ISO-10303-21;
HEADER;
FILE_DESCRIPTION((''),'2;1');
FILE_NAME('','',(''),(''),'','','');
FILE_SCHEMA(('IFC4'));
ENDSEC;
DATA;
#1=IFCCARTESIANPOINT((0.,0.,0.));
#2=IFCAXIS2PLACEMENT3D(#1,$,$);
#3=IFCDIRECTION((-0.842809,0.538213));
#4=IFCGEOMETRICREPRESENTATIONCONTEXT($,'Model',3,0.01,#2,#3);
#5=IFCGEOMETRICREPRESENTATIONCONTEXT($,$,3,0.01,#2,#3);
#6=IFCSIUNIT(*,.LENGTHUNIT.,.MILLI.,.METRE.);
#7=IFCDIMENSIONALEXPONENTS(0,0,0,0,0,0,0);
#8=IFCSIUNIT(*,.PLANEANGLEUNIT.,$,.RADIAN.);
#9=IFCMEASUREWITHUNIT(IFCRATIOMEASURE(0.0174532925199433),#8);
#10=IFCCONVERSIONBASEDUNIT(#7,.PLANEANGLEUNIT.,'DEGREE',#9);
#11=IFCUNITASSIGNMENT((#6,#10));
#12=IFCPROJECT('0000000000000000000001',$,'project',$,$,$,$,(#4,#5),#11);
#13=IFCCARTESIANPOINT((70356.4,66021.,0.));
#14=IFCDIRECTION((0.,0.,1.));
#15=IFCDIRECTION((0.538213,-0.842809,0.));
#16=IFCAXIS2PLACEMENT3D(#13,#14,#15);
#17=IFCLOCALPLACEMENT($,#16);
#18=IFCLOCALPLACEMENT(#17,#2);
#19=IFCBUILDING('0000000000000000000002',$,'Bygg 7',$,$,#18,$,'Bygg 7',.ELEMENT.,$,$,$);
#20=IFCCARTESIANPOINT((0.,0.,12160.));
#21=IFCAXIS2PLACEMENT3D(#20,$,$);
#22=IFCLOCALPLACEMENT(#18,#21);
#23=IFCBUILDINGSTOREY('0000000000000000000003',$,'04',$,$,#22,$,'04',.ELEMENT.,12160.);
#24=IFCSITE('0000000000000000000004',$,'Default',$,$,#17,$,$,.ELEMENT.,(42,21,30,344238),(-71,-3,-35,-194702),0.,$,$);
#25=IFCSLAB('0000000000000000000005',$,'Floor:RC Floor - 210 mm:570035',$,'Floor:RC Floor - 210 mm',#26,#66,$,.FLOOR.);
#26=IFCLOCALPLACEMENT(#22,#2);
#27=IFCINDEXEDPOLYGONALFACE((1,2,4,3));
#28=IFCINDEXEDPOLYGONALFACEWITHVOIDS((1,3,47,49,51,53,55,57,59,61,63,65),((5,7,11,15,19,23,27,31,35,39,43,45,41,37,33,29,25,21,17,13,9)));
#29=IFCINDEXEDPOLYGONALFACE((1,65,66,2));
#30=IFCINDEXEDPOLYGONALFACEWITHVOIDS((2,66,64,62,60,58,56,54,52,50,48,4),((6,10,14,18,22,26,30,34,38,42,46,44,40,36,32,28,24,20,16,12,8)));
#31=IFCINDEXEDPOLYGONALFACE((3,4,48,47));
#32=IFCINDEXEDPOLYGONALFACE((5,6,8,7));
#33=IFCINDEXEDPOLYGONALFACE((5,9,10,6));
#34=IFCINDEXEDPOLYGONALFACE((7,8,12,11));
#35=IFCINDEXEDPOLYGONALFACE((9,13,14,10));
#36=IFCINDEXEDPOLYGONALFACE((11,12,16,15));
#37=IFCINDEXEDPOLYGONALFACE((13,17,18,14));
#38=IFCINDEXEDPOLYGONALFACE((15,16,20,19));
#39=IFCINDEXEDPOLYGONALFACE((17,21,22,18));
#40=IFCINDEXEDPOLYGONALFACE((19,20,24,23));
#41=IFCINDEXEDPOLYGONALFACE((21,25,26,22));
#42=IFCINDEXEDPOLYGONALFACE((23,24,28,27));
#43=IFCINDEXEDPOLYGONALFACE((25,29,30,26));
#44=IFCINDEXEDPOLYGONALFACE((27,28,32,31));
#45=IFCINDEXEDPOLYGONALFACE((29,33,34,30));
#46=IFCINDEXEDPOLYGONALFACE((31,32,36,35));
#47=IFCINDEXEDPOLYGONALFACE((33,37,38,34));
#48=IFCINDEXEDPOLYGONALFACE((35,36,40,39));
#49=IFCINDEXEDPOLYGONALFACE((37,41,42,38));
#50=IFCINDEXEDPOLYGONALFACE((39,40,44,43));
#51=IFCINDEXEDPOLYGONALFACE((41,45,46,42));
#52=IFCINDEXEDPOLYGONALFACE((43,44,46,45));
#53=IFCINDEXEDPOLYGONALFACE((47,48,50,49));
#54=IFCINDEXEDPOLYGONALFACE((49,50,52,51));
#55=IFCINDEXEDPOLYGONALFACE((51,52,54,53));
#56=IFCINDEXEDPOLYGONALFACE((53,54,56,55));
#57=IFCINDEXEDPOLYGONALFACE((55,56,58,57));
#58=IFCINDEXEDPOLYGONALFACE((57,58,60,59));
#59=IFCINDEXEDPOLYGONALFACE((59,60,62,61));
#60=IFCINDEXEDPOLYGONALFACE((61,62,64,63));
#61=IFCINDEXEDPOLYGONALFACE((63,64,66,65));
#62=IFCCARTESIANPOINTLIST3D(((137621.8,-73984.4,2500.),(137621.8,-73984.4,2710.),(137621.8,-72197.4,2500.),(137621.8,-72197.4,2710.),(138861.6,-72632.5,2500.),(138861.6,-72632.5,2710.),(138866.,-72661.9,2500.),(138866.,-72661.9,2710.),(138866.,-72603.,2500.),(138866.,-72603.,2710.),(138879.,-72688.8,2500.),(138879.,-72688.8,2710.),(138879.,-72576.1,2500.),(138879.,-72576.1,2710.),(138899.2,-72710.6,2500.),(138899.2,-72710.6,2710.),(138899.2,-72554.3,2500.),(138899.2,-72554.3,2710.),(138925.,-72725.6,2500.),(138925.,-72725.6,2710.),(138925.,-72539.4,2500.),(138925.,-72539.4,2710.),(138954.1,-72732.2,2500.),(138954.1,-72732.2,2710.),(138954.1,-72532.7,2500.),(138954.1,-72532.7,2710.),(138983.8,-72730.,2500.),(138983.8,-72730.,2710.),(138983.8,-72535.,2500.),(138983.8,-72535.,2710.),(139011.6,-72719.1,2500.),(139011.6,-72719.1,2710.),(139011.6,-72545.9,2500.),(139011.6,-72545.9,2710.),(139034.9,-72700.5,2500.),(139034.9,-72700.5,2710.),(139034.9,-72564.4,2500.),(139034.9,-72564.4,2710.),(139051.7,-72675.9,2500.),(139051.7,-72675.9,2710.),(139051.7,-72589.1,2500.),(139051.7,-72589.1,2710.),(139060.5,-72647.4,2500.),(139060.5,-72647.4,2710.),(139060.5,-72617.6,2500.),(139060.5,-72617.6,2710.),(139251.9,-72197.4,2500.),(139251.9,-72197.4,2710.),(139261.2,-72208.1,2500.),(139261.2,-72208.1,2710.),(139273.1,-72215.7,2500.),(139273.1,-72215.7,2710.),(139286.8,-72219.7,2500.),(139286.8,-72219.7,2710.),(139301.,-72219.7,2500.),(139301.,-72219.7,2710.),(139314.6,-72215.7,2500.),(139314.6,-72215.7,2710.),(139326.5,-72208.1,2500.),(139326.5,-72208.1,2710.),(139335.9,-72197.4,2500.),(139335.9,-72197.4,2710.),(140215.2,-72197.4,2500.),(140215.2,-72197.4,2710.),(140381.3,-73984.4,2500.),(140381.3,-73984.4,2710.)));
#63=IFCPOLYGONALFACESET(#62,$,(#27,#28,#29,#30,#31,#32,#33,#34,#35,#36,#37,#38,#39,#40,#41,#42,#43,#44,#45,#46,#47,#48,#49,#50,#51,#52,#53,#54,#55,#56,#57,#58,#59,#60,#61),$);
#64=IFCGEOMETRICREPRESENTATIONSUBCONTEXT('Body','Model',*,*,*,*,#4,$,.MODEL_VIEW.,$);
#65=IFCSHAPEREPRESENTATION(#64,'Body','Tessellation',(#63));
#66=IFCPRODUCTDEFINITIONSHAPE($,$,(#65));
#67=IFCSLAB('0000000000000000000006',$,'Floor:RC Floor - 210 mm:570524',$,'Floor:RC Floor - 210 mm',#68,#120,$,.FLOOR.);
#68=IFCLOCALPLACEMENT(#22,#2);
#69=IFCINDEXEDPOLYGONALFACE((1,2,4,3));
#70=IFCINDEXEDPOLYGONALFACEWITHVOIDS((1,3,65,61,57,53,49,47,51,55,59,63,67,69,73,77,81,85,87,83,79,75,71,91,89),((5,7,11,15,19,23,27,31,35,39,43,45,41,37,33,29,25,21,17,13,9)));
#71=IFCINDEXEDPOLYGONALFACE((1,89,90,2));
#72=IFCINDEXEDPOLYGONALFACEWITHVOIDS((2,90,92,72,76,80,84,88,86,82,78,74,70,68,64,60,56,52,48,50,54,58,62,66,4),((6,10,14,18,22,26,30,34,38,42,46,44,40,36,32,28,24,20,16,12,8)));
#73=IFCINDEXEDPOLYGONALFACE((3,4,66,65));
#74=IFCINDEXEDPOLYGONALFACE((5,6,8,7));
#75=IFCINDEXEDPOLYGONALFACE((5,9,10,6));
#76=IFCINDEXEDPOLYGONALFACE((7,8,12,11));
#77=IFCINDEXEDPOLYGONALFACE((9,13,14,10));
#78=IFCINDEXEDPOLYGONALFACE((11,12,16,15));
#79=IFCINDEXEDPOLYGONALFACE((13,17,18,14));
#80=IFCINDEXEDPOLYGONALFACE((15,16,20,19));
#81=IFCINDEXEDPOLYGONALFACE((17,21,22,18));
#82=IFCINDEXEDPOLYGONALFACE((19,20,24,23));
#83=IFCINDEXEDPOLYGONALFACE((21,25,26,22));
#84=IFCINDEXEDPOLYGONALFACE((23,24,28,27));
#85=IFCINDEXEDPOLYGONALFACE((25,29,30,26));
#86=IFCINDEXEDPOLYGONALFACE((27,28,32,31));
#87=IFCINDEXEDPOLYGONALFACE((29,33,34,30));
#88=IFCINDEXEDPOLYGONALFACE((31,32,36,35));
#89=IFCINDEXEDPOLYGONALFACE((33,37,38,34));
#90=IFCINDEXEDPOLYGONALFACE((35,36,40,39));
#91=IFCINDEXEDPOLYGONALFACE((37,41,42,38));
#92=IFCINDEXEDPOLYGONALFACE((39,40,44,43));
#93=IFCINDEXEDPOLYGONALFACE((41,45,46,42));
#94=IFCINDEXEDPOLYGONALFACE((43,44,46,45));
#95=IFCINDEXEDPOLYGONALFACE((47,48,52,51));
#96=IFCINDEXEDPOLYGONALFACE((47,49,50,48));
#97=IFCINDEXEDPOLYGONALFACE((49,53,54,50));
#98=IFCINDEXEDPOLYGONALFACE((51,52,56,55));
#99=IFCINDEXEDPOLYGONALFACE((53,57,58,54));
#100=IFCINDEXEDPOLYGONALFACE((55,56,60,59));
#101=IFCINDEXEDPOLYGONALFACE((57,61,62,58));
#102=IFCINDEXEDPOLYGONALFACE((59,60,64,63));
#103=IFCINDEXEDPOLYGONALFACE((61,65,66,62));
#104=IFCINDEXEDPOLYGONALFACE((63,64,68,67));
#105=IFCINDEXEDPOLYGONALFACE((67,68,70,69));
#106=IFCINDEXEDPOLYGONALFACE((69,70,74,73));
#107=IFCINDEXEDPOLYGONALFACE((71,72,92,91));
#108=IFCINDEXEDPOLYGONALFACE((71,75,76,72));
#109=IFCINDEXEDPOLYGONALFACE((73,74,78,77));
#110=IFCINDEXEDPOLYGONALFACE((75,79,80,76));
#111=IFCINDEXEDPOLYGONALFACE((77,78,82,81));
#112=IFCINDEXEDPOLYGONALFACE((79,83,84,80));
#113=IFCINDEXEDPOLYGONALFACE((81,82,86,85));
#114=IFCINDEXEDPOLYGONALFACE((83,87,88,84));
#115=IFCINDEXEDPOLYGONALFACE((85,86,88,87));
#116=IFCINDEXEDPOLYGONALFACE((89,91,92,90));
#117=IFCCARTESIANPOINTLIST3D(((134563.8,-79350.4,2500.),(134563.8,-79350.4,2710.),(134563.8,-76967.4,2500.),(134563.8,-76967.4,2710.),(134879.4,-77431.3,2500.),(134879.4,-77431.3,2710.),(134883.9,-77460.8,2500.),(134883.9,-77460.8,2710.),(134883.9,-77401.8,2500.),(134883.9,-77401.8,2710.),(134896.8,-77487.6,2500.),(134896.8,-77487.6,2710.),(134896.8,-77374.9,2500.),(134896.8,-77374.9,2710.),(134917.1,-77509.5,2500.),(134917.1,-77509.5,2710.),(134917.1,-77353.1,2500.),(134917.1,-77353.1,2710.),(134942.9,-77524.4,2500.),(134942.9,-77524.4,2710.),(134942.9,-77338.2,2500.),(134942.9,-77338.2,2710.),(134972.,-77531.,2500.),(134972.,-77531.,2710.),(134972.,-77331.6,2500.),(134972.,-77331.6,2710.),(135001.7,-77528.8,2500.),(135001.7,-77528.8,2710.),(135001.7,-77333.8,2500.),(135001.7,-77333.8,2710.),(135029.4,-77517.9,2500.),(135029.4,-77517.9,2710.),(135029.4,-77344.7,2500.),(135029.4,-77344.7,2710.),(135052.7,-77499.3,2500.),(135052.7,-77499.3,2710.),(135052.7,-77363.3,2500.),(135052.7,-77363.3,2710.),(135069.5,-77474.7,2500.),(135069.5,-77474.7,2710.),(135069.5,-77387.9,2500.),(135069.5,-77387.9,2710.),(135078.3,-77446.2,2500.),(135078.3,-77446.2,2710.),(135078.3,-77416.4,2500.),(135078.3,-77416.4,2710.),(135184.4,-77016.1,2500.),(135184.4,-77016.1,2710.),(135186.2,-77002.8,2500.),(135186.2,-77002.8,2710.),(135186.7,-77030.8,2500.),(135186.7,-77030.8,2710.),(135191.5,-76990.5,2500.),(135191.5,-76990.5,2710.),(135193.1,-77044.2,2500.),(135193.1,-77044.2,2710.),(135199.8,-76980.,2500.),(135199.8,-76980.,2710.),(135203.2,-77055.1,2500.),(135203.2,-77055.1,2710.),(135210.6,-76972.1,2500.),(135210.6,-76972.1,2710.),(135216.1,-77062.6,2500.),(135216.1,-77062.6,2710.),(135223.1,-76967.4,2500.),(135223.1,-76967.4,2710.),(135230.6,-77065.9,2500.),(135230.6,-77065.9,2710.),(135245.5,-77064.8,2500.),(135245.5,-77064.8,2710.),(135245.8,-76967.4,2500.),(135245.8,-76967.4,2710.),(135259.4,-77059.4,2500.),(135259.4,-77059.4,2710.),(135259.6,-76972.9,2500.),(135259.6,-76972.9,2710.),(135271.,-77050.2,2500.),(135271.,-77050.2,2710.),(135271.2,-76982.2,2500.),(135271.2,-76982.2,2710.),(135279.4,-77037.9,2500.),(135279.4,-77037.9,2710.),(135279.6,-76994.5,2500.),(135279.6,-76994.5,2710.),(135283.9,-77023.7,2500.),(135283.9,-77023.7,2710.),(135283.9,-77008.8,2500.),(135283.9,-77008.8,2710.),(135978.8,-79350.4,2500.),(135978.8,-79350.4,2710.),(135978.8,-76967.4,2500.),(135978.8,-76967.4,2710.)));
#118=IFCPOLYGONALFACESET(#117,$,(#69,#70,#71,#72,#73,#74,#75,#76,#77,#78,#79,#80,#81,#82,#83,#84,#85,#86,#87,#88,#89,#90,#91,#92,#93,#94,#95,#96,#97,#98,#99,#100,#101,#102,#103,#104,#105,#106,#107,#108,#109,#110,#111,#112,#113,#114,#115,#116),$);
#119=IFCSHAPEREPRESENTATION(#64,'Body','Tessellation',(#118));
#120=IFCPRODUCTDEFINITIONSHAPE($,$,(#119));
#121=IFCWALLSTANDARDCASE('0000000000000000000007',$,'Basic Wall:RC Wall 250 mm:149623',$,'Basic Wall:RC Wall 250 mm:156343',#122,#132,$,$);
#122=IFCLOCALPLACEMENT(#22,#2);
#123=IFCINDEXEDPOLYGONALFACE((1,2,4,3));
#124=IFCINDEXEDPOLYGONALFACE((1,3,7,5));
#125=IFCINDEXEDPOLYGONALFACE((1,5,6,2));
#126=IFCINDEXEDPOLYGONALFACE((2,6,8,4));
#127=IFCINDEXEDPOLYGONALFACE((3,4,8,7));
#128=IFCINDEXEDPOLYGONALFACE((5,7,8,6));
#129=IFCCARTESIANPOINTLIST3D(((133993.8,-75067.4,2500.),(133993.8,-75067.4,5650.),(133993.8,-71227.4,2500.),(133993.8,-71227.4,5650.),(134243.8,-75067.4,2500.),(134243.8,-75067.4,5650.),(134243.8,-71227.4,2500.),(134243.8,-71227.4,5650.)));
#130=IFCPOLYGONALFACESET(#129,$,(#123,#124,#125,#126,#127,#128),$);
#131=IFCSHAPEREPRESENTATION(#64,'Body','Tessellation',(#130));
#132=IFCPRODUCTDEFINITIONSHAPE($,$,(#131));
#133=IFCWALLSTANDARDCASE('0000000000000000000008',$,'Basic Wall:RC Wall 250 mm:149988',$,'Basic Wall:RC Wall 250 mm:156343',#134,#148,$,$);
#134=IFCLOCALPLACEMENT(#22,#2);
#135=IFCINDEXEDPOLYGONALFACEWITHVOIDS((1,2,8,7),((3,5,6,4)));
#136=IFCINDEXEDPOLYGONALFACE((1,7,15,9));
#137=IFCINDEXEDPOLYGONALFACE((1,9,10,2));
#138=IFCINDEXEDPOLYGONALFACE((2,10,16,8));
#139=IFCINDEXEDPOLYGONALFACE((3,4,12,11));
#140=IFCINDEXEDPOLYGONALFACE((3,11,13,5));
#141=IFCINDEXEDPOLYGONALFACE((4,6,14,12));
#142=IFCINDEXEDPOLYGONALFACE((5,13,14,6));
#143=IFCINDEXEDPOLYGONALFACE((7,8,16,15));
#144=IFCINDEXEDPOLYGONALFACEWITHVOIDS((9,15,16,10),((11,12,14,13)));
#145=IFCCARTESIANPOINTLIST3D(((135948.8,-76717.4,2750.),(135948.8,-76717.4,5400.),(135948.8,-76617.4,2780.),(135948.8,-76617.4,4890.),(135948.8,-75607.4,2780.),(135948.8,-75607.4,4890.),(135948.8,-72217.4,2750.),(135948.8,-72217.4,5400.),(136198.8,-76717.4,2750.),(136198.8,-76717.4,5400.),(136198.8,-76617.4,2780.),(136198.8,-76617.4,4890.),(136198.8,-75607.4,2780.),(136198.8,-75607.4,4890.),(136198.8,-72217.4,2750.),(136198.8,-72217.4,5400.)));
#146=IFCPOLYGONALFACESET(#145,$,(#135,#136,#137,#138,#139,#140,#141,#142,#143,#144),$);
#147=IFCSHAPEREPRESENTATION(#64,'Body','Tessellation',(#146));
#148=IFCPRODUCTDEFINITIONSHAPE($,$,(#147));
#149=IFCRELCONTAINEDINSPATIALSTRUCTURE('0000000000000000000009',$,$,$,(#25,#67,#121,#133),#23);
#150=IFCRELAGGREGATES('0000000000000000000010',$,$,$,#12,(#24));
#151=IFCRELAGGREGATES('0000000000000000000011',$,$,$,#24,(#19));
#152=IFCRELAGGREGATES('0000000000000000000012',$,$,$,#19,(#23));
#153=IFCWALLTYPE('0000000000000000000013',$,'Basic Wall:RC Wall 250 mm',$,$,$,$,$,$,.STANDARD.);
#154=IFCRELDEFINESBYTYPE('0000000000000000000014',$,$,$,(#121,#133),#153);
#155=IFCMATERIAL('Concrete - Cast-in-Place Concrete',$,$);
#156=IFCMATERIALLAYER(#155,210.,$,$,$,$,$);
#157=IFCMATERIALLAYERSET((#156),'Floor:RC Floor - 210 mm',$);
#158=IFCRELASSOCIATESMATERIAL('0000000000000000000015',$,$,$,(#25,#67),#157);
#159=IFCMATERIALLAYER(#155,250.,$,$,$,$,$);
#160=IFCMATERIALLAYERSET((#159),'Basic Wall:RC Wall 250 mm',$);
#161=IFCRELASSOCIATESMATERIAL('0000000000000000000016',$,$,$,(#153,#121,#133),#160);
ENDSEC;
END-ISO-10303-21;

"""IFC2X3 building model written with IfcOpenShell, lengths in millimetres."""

from ifc_helpers import new_model, entity, si_unit, converted_unit, direction, frame, frame_2d, origin, origin_2d_with_axis, place, context, subcontext, project, spatial, polyline, rectangle, circle, outline, extrude, clip, bounded_halfspace, material, layer, layer_set, layer_usage, type_object, element, save


model = new_model("IFC2X3")

# Units and contexts
model_context = context("Model", 3, precision=0.01, world=origin(), true_north=direction((-0.842809, 0.538213)))
context_of_model = context(None, 3, precision=0.01, world=origin(), true_north=direction((-0.842809, 0.538213)))
body_context = subcontext(model_context, "Body", "Model", "MODEL_VIEW")
ifc_project = project(units=[si_unit("LENGTHUNIT", "METRE", prefix="MILLI"), converted_unit("PLANEANGLEUNIT", "DEGREE", entity("IfcRatioMeasure", 0.0174532925199433), si_unit("PLANEANGLEUNIT", "RADIAN"), dimensions=[0, 0, 0, 0, 0, 0, 0])], contexts=[model_context, context_of_model])

# Site, building, storey
site_placement = place(None, frame((70356.4, 66021.0, 0.0), z_axis=(0.0, 0.0, 1.0), x_axis=(0.538213, -0.842809, 0.0)))
site = spatial("IfcSite", under=ifc_project, at=site_placement, Name="Default", CompositionType="ELEMENT", RefLatitude=(42, 21, 30, 344238), RefLongitude=(-71, -3, -35, -194702), RefElevation=0.0)
building_placement = place(site_placement, origin())
building = spatial("IfcBuilding", under=site, at=building_placement, Name="Bygg 7", LongName="Bygg 7", CompositionType="ELEMENT")
storey_placement = place(building_placement, frame((0.0, 0.0, 12160.0)))
storey = spatial("IfcBuildingStorey", under=building, at=storey_placement, Name="04", LongName="04", CompositionType="ELEMENT", Elevation=12160.0)

# Slabs, openings
ifc_material_1 = material(Name="Concrete - Cast-in-Place Concrete")
ifc_layer_1 = layer(ifc_material_1, 210.0)
ifc_layer_set_1 = layer_set([ifc_layer_1], Name="Floor:RC Floor - 210 mm")
ifc_layer_usage_1 = layer_usage(ifc_layer_set_1, "AXIS3", "POSITIVE", 0.0)
slab_1_placement = place(storey_placement, frame((137621.8, -73984.4, 2500.0)))
slab_1 = element("IfcSlab", 1, at=slab_1_placement, inside=storey, material=ifc_layer_usage_1, Name="Floor:RC Floor - 210 mm:570035", ObjectType="Floor:RC Floor - 210 mm", PredefinedType="FLOOR", context=body_context, shape_type="SweptSolid", body=[
    extrude(outline(polyline([(1379.7, -893.5), (1379.7, 893.5), (-1213.7, 893.5), (-1379.7, -893.5), (1379.7, -893.5)])), frame((1379.7, 893.5, 210.0), z_axis=(0.0, 0.0, -1.0), x_axis=(-1.0, 0.0, 0.0)), (0.0, 0.0, 1.0), 210.0),
])
opening_1_placement = place(storey_placement, frame((137621.8, -73984.4, 2500.0)))
element("IfcOpeningElement", 2, at=opening_1_placement, cuts=slab_1, ObjectType="Opening", context=body_context, shape_type="SweptSolid", body=[
    extrude(circle(Radius=100.0, at=frame_2d((40.0, 458.4), x_axis=(1.0, 0.0))), frame((1379.7, 893.5, 210.0), z_axis=(0.0, 0.0, -1.0), x_axis=(-1.0, 0.0, 0.0)), (0.0, 0.0, 1.0), 210.0),
])
opening_2_placement = place(storey_placement, frame((137621.8, -73984.4, 2500.0)))
element("IfcOpeningElement", 3, at=opening_2_placement, cuts=slab_1, ObjectType="Opening", context=body_context, shape_type="SweptSolid", body=[
    extrude(circle(Radius=50.0, at=frame_2d((-292.3, 920.6), x_axis=(1.0, 0.0))), frame((1379.7, 893.5, 210.0), z_axis=(0.0, 0.0, -1.0), x_axis=(-1.0, 0.0, 0.0)), (0.0, 0.0, 1.0), 210.0),
])
ifc_layer_usage_2 = layer_usage(ifc_layer_set_1, "AXIS3", "POSITIVE", 0.0)
slab_2_placement = place(storey_placement, frame((134563.8, -79350.4, 2500.0)))
slab_2 = element("IfcSlab", 4, at=slab_2_placement, inside=storey, material=ifc_layer_usage_2, Name="Floor:RC Floor - 210 mm:570524", ObjectType="Floor:RC Floor - 210 mm", PredefinedType="FLOOR", context=body_context, shape_type="SweptSolid", body=[
    extrude(rectangle(XDim=2396.0, YDim=1415.0, at=frame_2d((0.0, -6.5), x_axis=(0.0, -1.0))), frame((707.5, 1191.5, 210.0), z_axis=(0.0, 0.0, -1.0), x_axis=(-1.0, 0.0, 0.0)), (0.0, 0.0, 1.0), 210.0),
])
opening_3_placement = place(storey_placement, frame((134563.8, -79350.4, 2500.0)))
element("IfcOpeningElement", 5, at=opening_3_placement, cuts=slab_2, ObjectType="Opening", context=body_context, shape_type="SweptSolid", body=[
    extrude(rectangle(XDim=1415.0, YDim=577.0, at=frame_2d((0.0, -1480.0), x_axis=(1.0, 0.0))), frame((707.5, 1191.5, 210.0), z_axis=(0.0, 0.0, -1.0), x_axis=(-1.0, 0.0, 0.0)), (0.0, 0.0, 1.0), 210.0),
])
opening_4_placement = place(storey_placement, frame((134563.8, -79350.4, 2500.0)))
element("IfcOpeningElement", 6, at=opening_4_placement, cuts=slab_2, ObjectType="Opening", context=body_context, shape_type="SweptSolid", body=[
    extrude(circle(Radius=100.0, at=frame_2d((291.9, 727.6), x_axis=(1.0, 0.0))), frame((707.5, 1191.5, 210.0), z_axis=(0.0, 0.0, -1.0), x_axis=(-1.0, 0.0, 0.0)), (0.0, 0.0, 1.0), 210.0),
])
opening_5_placement = place(storey_placement, frame((134563.8, -79350.4, 2500.0)))
element("IfcOpeningElement", 7, at=opening_5_placement, cuts=slab_2, ObjectType="Opening", context=body_context, shape_type="SweptSolid", body=[
    extrude(circle(Radius=50.0, at=frame_2d((36.9, 1142.8), x_axis=(1.0, 0.0))), frame((707.5, 1191.5, 210.0), z_axis=(0.0, 0.0, -1.0), x_axis=(-1.0, 0.0, 0.0)), (0.0, 0.0, 1.0), 210.0),
])

# Wall
ifc_layer_2 = layer(ifc_material_1, 250.0)
ifc_layer_set_2 = layer_set([ifc_layer_2], Name="Basic Wall:RC Wall 250 mm")
ifc_layer_usage_3 = layer_usage(ifc_layer_set_2, "AXIS2", "NEGATIVE", 125.0)
wall_type_1 = type_object("IfcWallType", Name="Basic Wall:RC Wall 250 mm", PredefinedType="STANDARD", material=ifc_layer_set_2)
wall_1_placement = place(storey_placement, frame((134118.8, -75067.4, 2500.0), z_axis=(0.0, 0.0, 1.0), x_axis=(0.0, 1.0, 0.0)))
element("IfcWallStandardCase", 8, at=wall_1_placement, inside=storey, type_object=wall_type_1, material=ifc_layer_usage_3, Name="Basic Wall:RC Wall 250 mm:149623", ObjectType="Basic Wall:RC Wall 250 mm:156343", context=body_context, shape_type="SweptSolid", body=[
    extrude(rectangle(XDim=3840.0, YDim=250.0, at=frame_2d((1920.0, 0.0), x_axis=(-1.0, 0.0))), origin(), (0.0, 0.0, 1.0), 3150.0),
])

# Wall, opening
ifc_layer_usage_4 = layer_usage(ifc_layer_set_2, "AXIS2", "NEGATIVE", 125.0)
wall_2_placement = place(storey_placement, frame((136073.8, -76717.4, 2750.0), z_axis=(0.0, 0.0, 1.0), x_axis=(0.0, 1.0, 0.0)))
wall_2 = element("IfcWallStandardCase", 9, at=wall_2_placement, inside=storey, type_object=wall_type_1, material=ifc_layer_usage_4, Name="Basic Wall:RC Wall 250 mm:149988", ObjectType="Basic Wall:RC Wall 250 mm:156343", context=body_context, shape_type="Clipping", body=[
    clip(clip(clip(extrude(rectangle(XDim=4500.0, YDim=250.0, at=frame_2d((2250.0, 0.0), x_axis=(-1.0, 0.0))), origin(), (0.0, 0.0, 1.0), 2650.0), bounded_halfspace(frame((0.0, -125.0, 2650.0), z_axis=(0.0, 0.0, -1.0), x_axis=(-0.99571, -0.092529, 0.0)), True, frame((0.0, -125.0, 2650.0)), polyline([(0.0, 0.0), (4500.0, 0.0), (4500.0, 250.0), (0.0, 250.0), (0.0, 0.0)]))), bounded_halfspace(frame((0.0, -125.0, 0.0), z_axis=(0.0, 0.0, 1.0), x_axis=(0.99571, 0.092529, 0.0)), True, frame((0.0, -125.0, 0.0)), polyline([(0.0, 0.0), (100.0, 0.0), (100.0, 250.0), (0.0, 250.0), (0.0, 0.0)]))), bounded_halfspace(frame((4500.0, 125.0, 0.0), z_axis=(0.0, 0.0, 1.0), x_axis=(0.99571, 0.092529, 0.0)), True, frame((4500.0, 125.0, 0.0)), polyline([(0.0, 0.0), (-3390.0, 0.0), (-3390.0, -250.0), (0.0, -250.0), (0.0, 0.0)]))),
])
opening_6_placement = place(wall_2_placement, origin())
element("IfcOpeningElement", 10, at=opening_6_placement, cuts=wall_2, ObjectType="Opening", context=body_context, shape_type="SweptSolid", body=[
    extrude(rectangle(XDim=2110.0, YDim=1010.0, at=origin_2d_with_axis()), frame((605.0, -125.0, 1085.0), z_axis=(0.0, 1.0, 0.0), x_axis=(0.0, 0.0, -1.0)), (0.0, 0.0, 1.0), 250.0),
])

save(model, "model.ifc")
